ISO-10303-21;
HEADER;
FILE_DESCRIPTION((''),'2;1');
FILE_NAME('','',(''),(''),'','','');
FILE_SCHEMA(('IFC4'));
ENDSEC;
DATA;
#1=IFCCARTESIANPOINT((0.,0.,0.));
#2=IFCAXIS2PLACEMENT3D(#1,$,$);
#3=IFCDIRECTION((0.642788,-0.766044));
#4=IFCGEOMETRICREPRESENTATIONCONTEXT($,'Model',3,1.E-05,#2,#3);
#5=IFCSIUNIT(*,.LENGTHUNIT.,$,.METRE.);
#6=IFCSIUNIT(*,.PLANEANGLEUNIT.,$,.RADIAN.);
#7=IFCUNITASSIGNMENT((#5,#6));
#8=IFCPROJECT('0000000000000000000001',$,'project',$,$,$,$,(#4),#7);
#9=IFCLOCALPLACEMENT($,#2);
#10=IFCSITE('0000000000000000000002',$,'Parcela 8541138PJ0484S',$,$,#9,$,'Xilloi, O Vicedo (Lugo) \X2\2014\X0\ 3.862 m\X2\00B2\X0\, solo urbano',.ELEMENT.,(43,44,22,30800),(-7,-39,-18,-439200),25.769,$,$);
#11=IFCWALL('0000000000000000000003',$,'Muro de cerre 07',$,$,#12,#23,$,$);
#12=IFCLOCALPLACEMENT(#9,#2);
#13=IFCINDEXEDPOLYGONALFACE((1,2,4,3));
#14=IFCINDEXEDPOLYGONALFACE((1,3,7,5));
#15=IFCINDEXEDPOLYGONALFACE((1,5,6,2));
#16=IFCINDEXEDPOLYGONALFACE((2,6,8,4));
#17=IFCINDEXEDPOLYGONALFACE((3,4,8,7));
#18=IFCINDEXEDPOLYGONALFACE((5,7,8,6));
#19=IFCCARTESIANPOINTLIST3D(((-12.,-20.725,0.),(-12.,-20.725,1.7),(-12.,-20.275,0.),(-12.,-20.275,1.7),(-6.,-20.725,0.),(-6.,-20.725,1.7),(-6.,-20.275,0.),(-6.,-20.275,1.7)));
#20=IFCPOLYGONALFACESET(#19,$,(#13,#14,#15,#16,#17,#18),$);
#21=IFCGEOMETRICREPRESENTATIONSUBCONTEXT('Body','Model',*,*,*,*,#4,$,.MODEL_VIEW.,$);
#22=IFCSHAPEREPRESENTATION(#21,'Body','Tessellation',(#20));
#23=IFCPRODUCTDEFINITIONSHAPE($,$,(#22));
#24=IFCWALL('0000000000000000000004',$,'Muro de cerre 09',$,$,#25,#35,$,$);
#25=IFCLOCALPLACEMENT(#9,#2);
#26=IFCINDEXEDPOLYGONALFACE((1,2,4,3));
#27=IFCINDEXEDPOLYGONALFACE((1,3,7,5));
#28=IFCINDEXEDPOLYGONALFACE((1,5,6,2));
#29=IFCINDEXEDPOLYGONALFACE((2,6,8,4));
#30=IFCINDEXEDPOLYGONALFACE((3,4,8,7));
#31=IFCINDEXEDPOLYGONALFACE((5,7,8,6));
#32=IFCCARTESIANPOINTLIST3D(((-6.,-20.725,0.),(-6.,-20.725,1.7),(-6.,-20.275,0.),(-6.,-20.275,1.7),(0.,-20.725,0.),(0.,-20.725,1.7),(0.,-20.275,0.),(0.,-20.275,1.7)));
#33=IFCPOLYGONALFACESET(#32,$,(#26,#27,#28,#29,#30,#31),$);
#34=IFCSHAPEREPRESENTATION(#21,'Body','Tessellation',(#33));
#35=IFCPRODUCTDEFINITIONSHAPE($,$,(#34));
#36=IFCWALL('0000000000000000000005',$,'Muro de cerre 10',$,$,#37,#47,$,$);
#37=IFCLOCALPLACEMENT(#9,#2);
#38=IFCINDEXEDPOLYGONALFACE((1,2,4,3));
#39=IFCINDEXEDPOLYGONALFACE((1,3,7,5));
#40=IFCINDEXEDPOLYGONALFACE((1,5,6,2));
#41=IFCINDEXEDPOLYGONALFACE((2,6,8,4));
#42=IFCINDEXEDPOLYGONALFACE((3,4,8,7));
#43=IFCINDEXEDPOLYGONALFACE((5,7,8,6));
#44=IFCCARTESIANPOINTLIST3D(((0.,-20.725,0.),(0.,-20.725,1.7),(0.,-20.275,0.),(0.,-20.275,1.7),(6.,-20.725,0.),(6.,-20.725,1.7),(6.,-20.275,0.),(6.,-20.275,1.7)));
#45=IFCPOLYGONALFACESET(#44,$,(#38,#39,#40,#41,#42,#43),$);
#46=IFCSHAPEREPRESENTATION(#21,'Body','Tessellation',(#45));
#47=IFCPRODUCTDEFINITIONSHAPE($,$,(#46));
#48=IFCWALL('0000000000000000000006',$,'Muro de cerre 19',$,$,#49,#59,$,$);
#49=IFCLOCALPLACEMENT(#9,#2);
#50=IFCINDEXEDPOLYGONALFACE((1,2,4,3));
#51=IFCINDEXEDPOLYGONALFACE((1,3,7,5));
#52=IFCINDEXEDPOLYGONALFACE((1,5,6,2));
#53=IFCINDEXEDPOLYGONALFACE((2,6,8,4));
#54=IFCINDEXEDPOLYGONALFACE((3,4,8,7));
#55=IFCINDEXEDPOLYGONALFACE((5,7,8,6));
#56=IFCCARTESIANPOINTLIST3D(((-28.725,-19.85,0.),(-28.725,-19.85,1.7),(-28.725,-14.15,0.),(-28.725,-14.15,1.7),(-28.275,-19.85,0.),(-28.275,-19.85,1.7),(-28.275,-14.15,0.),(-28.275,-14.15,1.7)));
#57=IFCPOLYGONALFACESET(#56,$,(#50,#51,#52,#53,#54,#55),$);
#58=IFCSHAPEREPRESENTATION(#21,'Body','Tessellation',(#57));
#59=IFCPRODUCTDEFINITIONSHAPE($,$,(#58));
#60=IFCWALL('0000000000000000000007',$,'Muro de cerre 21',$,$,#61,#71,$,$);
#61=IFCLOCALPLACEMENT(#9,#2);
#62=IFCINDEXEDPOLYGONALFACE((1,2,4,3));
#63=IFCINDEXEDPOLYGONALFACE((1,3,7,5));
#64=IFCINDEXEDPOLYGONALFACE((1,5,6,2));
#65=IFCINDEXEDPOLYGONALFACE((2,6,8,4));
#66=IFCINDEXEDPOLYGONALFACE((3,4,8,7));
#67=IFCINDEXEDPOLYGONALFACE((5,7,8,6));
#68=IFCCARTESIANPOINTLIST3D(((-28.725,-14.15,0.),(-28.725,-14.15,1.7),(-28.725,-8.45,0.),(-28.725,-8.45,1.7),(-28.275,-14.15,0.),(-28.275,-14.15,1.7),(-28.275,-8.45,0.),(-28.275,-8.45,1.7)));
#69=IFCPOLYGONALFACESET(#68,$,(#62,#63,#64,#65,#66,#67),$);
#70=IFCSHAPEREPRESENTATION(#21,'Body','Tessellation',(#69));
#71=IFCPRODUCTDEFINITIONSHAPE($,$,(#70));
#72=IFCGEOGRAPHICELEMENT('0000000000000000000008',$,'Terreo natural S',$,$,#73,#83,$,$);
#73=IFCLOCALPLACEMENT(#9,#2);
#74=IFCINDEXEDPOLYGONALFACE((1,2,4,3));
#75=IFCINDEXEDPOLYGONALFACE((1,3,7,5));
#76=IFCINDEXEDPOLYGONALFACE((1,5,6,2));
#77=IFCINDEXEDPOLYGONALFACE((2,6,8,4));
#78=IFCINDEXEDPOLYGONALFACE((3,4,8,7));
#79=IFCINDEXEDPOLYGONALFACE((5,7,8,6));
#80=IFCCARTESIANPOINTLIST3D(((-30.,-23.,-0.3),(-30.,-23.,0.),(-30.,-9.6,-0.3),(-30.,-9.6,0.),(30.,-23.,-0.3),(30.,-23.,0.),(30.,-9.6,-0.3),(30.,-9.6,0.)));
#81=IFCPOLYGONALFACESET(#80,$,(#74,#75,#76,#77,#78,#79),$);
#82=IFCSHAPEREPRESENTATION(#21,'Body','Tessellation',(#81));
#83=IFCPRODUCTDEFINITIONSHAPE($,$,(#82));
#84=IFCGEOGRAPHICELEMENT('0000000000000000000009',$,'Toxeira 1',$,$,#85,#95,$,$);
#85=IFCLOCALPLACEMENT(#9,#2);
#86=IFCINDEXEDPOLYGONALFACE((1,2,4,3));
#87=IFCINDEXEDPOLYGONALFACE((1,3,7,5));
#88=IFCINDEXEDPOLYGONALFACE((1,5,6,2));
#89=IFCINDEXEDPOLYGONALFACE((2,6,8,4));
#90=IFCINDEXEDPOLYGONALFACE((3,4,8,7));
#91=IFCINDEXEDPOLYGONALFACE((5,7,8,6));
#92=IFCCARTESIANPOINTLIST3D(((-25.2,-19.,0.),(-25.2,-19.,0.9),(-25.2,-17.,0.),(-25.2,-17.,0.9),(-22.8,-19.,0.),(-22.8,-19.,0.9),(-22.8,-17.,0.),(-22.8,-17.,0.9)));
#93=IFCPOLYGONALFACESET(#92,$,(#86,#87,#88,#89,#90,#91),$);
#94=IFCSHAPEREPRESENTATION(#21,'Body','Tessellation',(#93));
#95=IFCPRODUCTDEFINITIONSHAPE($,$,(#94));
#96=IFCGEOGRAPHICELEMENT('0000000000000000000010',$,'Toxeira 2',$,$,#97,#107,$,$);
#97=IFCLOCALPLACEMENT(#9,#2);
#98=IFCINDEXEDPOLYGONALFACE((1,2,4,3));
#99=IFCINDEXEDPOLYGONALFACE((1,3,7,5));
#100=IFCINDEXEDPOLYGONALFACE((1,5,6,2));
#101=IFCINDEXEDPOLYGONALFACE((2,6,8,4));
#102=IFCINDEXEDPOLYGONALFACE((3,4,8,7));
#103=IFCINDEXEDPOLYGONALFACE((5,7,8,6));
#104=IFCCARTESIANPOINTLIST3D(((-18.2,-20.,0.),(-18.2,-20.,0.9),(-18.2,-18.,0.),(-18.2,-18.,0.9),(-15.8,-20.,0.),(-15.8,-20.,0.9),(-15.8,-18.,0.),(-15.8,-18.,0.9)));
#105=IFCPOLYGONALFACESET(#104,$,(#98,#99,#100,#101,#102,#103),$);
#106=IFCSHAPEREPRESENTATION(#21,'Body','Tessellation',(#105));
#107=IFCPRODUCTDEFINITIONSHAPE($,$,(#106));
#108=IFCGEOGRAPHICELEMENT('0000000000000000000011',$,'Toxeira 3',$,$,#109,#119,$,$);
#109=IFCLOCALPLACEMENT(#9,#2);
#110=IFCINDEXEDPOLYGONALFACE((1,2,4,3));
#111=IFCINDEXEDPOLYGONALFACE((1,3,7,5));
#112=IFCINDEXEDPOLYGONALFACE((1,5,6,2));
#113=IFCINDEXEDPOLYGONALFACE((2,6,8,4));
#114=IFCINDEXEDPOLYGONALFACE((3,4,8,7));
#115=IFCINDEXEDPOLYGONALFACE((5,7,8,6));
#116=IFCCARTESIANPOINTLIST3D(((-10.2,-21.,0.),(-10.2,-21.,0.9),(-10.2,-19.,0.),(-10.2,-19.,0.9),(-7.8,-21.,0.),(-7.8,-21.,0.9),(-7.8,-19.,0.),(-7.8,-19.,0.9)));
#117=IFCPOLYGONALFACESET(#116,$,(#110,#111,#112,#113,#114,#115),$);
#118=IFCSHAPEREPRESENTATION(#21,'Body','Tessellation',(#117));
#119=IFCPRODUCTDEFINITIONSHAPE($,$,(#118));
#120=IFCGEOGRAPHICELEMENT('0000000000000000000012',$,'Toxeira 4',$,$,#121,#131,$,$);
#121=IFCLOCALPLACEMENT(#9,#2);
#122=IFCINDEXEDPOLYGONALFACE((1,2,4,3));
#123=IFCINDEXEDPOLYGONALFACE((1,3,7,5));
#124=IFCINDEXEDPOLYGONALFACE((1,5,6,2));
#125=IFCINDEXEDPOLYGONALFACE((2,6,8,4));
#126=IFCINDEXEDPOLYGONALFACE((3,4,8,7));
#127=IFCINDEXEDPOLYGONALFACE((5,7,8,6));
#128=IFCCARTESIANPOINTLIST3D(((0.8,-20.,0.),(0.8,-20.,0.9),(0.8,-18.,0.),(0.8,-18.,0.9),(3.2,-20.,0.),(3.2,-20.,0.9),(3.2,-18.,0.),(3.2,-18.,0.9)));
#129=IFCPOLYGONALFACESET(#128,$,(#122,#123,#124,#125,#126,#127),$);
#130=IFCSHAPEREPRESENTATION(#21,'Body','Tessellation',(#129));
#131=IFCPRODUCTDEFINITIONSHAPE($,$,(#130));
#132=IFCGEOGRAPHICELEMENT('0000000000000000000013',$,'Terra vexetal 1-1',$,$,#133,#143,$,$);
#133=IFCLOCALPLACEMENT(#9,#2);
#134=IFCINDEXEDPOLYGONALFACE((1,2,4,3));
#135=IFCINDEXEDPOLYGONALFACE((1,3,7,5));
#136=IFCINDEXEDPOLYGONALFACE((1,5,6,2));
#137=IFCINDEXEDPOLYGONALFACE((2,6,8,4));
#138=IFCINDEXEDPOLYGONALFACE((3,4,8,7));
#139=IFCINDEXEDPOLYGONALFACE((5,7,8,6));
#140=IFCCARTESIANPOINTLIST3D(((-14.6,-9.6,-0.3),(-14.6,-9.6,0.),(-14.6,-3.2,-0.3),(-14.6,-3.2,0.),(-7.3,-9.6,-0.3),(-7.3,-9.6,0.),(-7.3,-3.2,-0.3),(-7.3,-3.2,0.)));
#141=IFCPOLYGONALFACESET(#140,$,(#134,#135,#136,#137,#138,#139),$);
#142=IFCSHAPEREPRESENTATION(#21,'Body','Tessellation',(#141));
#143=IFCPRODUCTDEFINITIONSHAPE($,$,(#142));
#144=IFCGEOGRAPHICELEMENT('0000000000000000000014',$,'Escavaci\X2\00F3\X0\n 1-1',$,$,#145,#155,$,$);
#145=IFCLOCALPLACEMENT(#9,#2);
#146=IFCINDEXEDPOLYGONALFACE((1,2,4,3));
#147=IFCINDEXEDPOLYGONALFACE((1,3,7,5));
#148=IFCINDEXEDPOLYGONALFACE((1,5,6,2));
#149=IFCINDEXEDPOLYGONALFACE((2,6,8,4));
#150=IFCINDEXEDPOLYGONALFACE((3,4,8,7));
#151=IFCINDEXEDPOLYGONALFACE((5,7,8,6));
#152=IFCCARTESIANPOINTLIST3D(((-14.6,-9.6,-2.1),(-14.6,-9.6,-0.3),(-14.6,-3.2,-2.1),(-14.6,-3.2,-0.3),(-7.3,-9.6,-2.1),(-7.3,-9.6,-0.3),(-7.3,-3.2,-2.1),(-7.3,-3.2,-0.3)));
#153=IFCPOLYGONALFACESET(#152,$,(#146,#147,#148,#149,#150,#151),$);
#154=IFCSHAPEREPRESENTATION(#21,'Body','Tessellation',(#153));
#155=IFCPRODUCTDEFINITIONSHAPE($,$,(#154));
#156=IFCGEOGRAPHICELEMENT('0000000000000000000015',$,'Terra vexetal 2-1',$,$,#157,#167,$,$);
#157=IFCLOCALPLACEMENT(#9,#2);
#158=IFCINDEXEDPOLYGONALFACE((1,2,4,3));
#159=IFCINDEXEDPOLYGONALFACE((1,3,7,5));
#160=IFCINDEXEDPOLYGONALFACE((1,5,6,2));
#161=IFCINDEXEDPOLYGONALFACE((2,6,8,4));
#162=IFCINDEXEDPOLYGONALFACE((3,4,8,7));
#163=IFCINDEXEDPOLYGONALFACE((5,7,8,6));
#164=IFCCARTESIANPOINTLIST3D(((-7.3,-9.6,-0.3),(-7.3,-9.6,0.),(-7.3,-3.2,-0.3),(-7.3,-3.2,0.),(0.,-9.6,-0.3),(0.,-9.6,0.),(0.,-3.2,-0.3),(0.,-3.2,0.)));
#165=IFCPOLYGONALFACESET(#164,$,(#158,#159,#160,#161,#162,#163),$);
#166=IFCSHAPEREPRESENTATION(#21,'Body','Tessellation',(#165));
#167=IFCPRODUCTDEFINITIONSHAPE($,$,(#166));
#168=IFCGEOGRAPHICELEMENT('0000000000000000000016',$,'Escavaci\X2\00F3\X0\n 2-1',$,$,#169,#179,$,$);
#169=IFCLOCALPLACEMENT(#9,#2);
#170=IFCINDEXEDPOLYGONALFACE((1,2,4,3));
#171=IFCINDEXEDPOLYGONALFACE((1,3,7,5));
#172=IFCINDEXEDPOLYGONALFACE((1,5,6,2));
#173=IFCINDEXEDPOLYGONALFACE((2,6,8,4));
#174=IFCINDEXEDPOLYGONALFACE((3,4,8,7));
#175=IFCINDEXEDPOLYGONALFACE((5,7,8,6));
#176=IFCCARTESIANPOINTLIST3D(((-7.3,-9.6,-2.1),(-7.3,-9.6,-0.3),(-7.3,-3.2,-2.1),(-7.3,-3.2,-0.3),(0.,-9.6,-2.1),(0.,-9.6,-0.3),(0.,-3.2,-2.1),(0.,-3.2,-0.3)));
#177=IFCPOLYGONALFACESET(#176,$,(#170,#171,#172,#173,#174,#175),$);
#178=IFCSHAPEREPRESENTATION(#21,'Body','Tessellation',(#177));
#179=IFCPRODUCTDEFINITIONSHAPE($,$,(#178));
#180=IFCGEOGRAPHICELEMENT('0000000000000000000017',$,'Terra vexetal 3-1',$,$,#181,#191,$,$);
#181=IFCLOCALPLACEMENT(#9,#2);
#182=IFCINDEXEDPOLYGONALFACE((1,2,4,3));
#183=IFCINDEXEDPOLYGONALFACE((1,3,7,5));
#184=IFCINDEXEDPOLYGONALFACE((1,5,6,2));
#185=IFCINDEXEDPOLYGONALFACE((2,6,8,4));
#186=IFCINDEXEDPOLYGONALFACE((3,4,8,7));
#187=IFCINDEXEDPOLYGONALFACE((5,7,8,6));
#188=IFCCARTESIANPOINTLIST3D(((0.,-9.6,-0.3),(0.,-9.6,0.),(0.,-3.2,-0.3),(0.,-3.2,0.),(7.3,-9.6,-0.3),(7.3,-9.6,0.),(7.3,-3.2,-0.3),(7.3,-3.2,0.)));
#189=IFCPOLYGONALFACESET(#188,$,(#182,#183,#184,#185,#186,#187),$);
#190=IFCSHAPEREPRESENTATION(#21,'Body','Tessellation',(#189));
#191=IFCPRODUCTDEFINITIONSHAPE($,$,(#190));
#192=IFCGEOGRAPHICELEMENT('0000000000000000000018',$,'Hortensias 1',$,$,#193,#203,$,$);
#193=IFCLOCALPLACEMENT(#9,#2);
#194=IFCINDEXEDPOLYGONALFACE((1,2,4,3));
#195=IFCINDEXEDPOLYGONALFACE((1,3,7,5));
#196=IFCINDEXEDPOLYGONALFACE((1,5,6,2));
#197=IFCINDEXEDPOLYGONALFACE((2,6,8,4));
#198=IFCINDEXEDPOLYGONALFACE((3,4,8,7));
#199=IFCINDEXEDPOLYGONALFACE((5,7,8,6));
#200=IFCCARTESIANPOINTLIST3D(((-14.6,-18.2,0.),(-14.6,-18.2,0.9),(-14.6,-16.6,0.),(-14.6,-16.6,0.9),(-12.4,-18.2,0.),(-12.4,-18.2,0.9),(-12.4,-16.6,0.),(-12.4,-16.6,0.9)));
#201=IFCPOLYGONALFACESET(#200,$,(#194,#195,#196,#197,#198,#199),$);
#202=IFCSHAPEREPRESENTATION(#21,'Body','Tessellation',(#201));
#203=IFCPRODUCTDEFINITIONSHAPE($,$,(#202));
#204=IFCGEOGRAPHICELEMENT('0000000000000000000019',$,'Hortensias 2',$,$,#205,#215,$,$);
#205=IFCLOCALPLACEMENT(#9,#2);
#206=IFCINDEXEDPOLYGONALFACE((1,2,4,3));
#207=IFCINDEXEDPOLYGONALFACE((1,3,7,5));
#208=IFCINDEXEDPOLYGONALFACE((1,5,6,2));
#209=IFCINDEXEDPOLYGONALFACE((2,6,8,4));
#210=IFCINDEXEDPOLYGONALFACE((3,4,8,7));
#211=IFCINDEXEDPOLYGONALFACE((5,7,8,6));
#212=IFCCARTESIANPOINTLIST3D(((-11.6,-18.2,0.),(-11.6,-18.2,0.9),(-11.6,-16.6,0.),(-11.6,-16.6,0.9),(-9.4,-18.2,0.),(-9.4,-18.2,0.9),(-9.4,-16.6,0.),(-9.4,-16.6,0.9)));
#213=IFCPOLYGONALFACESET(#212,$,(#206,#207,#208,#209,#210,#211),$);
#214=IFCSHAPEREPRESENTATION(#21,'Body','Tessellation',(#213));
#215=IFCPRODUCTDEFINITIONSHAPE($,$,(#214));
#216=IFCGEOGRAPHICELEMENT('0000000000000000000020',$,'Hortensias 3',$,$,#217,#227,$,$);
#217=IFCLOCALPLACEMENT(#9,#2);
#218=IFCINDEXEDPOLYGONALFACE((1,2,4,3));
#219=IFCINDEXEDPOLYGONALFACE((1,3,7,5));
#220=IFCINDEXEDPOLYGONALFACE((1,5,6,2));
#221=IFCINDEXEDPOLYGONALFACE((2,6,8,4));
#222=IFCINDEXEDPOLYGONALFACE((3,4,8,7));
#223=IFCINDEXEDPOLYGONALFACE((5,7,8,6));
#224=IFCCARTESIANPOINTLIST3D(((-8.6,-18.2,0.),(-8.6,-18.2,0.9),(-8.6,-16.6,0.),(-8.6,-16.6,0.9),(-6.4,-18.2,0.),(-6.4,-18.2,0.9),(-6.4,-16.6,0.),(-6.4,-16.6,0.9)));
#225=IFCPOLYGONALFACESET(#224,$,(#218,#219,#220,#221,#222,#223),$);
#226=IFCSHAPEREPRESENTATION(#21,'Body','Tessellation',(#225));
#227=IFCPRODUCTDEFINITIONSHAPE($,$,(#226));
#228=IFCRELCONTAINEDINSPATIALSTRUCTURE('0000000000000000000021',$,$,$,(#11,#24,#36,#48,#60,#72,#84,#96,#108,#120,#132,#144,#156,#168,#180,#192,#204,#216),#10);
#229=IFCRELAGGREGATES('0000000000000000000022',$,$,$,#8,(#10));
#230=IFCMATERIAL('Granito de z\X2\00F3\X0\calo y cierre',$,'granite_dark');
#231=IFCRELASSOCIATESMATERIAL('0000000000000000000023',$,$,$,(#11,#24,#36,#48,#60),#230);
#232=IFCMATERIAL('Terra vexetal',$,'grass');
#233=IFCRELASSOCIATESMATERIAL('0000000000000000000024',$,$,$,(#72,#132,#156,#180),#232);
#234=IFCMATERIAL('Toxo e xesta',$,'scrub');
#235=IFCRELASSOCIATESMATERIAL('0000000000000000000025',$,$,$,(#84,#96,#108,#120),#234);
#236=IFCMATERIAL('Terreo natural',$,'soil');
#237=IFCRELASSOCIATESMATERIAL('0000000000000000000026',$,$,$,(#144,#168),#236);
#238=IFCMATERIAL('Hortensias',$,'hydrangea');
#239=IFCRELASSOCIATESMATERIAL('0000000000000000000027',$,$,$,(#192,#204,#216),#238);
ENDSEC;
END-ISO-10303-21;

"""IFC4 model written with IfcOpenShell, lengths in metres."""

from ifc_helpers import new_model, si_unit, direction, frame, origin, origin_2d, place, context, subcontext, project, spatial, rectangle, extrude, material, element, save


model = new_model("IFC4")

# Units and contexts
model_context = context("Model", 3, precision=1e-05, world=origin(), true_north=direction((0.642788, -0.766044)))
body_context = subcontext(model_context, "Body", "Model", "MODEL_VIEW")
ifc_project = project(units=[si_unit("LENGTHUNIT", "METRE"), si_unit("PLANEANGLEUNIT", "RADIAN")], contexts=[model_context])

# Site
site_placement = place(None, origin())
site = spatial("IfcSite", under=ifc_project, at=site_placement, Name="Parcela 8541138PJ0484S", LongName="Xilloi, O Vicedo (Lugo) — 3.862 m², solo urbano", CompositionType="ELEMENT", RefLatitude=(43, 44, 22, 30800), RefLongitude=(-7, -39, -18, -439200), RefElevation=25.769)

# Walls
ifc_material_1 = material(Name="Granito de zócalo y cierre", Category="granite_dark")
for number, where, name in (
    (1, (-9.0, -20.5, 0.85), "Muro de cerre 07"),
    (2, (-3.0, -20.5, 0.85), "Muro de cerre 09"),
    (3, (3.0, -20.5, 0.85), "Muro de cerre 10"),
):
    element("IfcWall", number, at=place(site_placement, frame(where)), inside=site, material=ifc_material_1, Name=name, context=body_context, shape_type="SweptSolid", body=[
        extrude(rectangle(XDim=6.0, YDim=0.45, at=origin_2d()), frame((0.0, 0.0, -0.85)), (0.0, 0.0, 1.0), 1.7),
    ])
for number, where, name in (
    (4, (-28.5, -17.0, 0.85), "Muro de cerre 19"),
    (5, (-28.5, -11.3, 0.85), "Muro de cerre 21"),
):
    element("IfcWall", number, at=place(site_placement, frame(where)), inside=site, material=ifc_material_1, Name=name, context=body_context, shape_type="SweptSolid", body=[
        extrude(rectangle(XDim=0.45, YDim=5.7, at=origin_2d()), frame((0.0, 0.0, -0.85)), (0.0, 0.0, 1.0), 1.7),
    ])

# Geographic elements
ifc_material_2 = material(Name="Terra vexetal", Category="grass")
geographic_element_1_placement = place(site_placement, frame((0.0, -16.3, -0.15)))
element("IfcGeographicElement", 6, at=geographic_element_1_placement, inside=site, material=ifc_material_2, Name="Terreo natural S", context=body_context, shape_type="SweptSolid", body=[
    extrude(rectangle(XDim=60.0, YDim=13.4, at=origin_2d()), frame((0.0, 0.0, -0.15)), (0.0, 0.0, 1.0), 0.3),
])
ifc_material_3 = material(Name="Toxo e xesta", Category="scrub")
for number, where, name in (
    (7, (-24.0, -18.0, 0.45), "Toxeira 1"),
    (8, (-17.0, -19.0, 0.45), "Toxeira 2"),
    (9, (-9.0, -20.0, 0.45), "Toxeira 3"),
    (10, (2.0, -19.0, 0.45), "Toxeira 4"),
):
    element("IfcGeographicElement", number, at=place(site_placement, frame(where)), inside=site, material=ifc_material_3, Name=name, context=body_context, shape_type="SweptSolid", body=[
        extrude(rectangle(XDim=2.4, YDim=2.0, at=origin_2d()), frame((0.0, 0.0, -0.45)), (0.0, 0.0, 1.0), 0.9),
    ])
geographic_element_2_placement = place(site_placement, frame((-10.95, -6.4, -0.15)))
element("IfcGeographicElement", 11, at=geographic_element_2_placement, inside=site, material=ifc_material_2, Name="Terra vexetal 1-1", context=body_context, shape_type="SweptSolid", body=[
    extrude(rectangle(XDim=7.3, YDim=6.4, at=origin_2d()), frame((0.0, 0.0, -0.15)), (0.0, 0.0, 1.0), 0.3),
])
ifc_material_4 = material(Name="Terreo natural", Category="soil")
geographic_element_3_placement = place(site_placement, frame((-10.95, -6.4, -1.2)))
element("IfcGeographicElement", 12, at=geographic_element_3_placement, inside=site, material=ifc_material_4, Name="Escavación 1-1", context=body_context, shape_type="SweptSolid", body=[
    extrude(rectangle(XDim=7.3, YDim=6.4, at=origin_2d()), frame((0.0, 0.0, -0.9)), (0.0, 0.0, 1.0), 1.8),
])
geographic_element_4_placement = place(site_placement, frame((-3.65, -6.4, -0.15)))
element("IfcGeographicElement", 13, at=geographic_element_4_placement, inside=site, material=ifc_material_2, Name="Terra vexetal 2-1", context=body_context, shape_type="SweptSolid", body=[
    extrude(rectangle(XDim=7.3, YDim=6.4, at=origin_2d()), frame((0.0, 0.0, -0.15)), (0.0, 0.0, 1.0), 0.3),
])
geographic_element_5_placement = place(site_placement, frame((-3.65, -6.4, -1.2)))
element("IfcGeographicElement", 14, at=geographic_element_5_placement, inside=site, material=ifc_material_4, Name="Escavación 2-1", context=body_context, shape_type="SweptSolid", body=[
    extrude(rectangle(XDim=7.3, YDim=6.4, at=origin_2d()), frame((0.0, 0.0, -0.9)), (0.0, 0.0, 1.0), 1.8),
])
geographic_element_6_placement = place(site_placement, frame((3.65, -6.4, -0.15)))
element("IfcGeographicElement", 15, at=geographic_element_6_placement, inside=site, material=ifc_material_2, Name="Terra vexetal 3-1", context=body_context, shape_type="SweptSolid", body=[
    extrude(rectangle(XDim=7.3, YDim=6.4, at=origin_2d()), frame((0.0, 0.0, -0.15)), (0.0, 0.0, 1.0), 0.3),
])
ifc_material_5 = material(Name="Hortensias", Category="hydrangea")
for number, where, name in (
    (16, (-13.5, -17.4, 0.45), "Hortensias 1"),
    (17, (-10.5, -17.4, 0.45), "Hortensias 2"),
    (18, (-7.5, -17.4, 0.45), "Hortensias 3"),
):
    element("IfcGeographicElement", number, at=place(site_placement, frame(where)), inside=site, material=ifc_material_5, Name=name, context=body_context, shape_type="SweptSolid", body=[
        extrude(rectangle(XDim=2.2, YDim=1.6, at=origin_2d()), frame((0.0, 0.0, -0.45)), (0.0, 0.0, 1.0), 0.9),
    ])

save(model, "model.ifc")
